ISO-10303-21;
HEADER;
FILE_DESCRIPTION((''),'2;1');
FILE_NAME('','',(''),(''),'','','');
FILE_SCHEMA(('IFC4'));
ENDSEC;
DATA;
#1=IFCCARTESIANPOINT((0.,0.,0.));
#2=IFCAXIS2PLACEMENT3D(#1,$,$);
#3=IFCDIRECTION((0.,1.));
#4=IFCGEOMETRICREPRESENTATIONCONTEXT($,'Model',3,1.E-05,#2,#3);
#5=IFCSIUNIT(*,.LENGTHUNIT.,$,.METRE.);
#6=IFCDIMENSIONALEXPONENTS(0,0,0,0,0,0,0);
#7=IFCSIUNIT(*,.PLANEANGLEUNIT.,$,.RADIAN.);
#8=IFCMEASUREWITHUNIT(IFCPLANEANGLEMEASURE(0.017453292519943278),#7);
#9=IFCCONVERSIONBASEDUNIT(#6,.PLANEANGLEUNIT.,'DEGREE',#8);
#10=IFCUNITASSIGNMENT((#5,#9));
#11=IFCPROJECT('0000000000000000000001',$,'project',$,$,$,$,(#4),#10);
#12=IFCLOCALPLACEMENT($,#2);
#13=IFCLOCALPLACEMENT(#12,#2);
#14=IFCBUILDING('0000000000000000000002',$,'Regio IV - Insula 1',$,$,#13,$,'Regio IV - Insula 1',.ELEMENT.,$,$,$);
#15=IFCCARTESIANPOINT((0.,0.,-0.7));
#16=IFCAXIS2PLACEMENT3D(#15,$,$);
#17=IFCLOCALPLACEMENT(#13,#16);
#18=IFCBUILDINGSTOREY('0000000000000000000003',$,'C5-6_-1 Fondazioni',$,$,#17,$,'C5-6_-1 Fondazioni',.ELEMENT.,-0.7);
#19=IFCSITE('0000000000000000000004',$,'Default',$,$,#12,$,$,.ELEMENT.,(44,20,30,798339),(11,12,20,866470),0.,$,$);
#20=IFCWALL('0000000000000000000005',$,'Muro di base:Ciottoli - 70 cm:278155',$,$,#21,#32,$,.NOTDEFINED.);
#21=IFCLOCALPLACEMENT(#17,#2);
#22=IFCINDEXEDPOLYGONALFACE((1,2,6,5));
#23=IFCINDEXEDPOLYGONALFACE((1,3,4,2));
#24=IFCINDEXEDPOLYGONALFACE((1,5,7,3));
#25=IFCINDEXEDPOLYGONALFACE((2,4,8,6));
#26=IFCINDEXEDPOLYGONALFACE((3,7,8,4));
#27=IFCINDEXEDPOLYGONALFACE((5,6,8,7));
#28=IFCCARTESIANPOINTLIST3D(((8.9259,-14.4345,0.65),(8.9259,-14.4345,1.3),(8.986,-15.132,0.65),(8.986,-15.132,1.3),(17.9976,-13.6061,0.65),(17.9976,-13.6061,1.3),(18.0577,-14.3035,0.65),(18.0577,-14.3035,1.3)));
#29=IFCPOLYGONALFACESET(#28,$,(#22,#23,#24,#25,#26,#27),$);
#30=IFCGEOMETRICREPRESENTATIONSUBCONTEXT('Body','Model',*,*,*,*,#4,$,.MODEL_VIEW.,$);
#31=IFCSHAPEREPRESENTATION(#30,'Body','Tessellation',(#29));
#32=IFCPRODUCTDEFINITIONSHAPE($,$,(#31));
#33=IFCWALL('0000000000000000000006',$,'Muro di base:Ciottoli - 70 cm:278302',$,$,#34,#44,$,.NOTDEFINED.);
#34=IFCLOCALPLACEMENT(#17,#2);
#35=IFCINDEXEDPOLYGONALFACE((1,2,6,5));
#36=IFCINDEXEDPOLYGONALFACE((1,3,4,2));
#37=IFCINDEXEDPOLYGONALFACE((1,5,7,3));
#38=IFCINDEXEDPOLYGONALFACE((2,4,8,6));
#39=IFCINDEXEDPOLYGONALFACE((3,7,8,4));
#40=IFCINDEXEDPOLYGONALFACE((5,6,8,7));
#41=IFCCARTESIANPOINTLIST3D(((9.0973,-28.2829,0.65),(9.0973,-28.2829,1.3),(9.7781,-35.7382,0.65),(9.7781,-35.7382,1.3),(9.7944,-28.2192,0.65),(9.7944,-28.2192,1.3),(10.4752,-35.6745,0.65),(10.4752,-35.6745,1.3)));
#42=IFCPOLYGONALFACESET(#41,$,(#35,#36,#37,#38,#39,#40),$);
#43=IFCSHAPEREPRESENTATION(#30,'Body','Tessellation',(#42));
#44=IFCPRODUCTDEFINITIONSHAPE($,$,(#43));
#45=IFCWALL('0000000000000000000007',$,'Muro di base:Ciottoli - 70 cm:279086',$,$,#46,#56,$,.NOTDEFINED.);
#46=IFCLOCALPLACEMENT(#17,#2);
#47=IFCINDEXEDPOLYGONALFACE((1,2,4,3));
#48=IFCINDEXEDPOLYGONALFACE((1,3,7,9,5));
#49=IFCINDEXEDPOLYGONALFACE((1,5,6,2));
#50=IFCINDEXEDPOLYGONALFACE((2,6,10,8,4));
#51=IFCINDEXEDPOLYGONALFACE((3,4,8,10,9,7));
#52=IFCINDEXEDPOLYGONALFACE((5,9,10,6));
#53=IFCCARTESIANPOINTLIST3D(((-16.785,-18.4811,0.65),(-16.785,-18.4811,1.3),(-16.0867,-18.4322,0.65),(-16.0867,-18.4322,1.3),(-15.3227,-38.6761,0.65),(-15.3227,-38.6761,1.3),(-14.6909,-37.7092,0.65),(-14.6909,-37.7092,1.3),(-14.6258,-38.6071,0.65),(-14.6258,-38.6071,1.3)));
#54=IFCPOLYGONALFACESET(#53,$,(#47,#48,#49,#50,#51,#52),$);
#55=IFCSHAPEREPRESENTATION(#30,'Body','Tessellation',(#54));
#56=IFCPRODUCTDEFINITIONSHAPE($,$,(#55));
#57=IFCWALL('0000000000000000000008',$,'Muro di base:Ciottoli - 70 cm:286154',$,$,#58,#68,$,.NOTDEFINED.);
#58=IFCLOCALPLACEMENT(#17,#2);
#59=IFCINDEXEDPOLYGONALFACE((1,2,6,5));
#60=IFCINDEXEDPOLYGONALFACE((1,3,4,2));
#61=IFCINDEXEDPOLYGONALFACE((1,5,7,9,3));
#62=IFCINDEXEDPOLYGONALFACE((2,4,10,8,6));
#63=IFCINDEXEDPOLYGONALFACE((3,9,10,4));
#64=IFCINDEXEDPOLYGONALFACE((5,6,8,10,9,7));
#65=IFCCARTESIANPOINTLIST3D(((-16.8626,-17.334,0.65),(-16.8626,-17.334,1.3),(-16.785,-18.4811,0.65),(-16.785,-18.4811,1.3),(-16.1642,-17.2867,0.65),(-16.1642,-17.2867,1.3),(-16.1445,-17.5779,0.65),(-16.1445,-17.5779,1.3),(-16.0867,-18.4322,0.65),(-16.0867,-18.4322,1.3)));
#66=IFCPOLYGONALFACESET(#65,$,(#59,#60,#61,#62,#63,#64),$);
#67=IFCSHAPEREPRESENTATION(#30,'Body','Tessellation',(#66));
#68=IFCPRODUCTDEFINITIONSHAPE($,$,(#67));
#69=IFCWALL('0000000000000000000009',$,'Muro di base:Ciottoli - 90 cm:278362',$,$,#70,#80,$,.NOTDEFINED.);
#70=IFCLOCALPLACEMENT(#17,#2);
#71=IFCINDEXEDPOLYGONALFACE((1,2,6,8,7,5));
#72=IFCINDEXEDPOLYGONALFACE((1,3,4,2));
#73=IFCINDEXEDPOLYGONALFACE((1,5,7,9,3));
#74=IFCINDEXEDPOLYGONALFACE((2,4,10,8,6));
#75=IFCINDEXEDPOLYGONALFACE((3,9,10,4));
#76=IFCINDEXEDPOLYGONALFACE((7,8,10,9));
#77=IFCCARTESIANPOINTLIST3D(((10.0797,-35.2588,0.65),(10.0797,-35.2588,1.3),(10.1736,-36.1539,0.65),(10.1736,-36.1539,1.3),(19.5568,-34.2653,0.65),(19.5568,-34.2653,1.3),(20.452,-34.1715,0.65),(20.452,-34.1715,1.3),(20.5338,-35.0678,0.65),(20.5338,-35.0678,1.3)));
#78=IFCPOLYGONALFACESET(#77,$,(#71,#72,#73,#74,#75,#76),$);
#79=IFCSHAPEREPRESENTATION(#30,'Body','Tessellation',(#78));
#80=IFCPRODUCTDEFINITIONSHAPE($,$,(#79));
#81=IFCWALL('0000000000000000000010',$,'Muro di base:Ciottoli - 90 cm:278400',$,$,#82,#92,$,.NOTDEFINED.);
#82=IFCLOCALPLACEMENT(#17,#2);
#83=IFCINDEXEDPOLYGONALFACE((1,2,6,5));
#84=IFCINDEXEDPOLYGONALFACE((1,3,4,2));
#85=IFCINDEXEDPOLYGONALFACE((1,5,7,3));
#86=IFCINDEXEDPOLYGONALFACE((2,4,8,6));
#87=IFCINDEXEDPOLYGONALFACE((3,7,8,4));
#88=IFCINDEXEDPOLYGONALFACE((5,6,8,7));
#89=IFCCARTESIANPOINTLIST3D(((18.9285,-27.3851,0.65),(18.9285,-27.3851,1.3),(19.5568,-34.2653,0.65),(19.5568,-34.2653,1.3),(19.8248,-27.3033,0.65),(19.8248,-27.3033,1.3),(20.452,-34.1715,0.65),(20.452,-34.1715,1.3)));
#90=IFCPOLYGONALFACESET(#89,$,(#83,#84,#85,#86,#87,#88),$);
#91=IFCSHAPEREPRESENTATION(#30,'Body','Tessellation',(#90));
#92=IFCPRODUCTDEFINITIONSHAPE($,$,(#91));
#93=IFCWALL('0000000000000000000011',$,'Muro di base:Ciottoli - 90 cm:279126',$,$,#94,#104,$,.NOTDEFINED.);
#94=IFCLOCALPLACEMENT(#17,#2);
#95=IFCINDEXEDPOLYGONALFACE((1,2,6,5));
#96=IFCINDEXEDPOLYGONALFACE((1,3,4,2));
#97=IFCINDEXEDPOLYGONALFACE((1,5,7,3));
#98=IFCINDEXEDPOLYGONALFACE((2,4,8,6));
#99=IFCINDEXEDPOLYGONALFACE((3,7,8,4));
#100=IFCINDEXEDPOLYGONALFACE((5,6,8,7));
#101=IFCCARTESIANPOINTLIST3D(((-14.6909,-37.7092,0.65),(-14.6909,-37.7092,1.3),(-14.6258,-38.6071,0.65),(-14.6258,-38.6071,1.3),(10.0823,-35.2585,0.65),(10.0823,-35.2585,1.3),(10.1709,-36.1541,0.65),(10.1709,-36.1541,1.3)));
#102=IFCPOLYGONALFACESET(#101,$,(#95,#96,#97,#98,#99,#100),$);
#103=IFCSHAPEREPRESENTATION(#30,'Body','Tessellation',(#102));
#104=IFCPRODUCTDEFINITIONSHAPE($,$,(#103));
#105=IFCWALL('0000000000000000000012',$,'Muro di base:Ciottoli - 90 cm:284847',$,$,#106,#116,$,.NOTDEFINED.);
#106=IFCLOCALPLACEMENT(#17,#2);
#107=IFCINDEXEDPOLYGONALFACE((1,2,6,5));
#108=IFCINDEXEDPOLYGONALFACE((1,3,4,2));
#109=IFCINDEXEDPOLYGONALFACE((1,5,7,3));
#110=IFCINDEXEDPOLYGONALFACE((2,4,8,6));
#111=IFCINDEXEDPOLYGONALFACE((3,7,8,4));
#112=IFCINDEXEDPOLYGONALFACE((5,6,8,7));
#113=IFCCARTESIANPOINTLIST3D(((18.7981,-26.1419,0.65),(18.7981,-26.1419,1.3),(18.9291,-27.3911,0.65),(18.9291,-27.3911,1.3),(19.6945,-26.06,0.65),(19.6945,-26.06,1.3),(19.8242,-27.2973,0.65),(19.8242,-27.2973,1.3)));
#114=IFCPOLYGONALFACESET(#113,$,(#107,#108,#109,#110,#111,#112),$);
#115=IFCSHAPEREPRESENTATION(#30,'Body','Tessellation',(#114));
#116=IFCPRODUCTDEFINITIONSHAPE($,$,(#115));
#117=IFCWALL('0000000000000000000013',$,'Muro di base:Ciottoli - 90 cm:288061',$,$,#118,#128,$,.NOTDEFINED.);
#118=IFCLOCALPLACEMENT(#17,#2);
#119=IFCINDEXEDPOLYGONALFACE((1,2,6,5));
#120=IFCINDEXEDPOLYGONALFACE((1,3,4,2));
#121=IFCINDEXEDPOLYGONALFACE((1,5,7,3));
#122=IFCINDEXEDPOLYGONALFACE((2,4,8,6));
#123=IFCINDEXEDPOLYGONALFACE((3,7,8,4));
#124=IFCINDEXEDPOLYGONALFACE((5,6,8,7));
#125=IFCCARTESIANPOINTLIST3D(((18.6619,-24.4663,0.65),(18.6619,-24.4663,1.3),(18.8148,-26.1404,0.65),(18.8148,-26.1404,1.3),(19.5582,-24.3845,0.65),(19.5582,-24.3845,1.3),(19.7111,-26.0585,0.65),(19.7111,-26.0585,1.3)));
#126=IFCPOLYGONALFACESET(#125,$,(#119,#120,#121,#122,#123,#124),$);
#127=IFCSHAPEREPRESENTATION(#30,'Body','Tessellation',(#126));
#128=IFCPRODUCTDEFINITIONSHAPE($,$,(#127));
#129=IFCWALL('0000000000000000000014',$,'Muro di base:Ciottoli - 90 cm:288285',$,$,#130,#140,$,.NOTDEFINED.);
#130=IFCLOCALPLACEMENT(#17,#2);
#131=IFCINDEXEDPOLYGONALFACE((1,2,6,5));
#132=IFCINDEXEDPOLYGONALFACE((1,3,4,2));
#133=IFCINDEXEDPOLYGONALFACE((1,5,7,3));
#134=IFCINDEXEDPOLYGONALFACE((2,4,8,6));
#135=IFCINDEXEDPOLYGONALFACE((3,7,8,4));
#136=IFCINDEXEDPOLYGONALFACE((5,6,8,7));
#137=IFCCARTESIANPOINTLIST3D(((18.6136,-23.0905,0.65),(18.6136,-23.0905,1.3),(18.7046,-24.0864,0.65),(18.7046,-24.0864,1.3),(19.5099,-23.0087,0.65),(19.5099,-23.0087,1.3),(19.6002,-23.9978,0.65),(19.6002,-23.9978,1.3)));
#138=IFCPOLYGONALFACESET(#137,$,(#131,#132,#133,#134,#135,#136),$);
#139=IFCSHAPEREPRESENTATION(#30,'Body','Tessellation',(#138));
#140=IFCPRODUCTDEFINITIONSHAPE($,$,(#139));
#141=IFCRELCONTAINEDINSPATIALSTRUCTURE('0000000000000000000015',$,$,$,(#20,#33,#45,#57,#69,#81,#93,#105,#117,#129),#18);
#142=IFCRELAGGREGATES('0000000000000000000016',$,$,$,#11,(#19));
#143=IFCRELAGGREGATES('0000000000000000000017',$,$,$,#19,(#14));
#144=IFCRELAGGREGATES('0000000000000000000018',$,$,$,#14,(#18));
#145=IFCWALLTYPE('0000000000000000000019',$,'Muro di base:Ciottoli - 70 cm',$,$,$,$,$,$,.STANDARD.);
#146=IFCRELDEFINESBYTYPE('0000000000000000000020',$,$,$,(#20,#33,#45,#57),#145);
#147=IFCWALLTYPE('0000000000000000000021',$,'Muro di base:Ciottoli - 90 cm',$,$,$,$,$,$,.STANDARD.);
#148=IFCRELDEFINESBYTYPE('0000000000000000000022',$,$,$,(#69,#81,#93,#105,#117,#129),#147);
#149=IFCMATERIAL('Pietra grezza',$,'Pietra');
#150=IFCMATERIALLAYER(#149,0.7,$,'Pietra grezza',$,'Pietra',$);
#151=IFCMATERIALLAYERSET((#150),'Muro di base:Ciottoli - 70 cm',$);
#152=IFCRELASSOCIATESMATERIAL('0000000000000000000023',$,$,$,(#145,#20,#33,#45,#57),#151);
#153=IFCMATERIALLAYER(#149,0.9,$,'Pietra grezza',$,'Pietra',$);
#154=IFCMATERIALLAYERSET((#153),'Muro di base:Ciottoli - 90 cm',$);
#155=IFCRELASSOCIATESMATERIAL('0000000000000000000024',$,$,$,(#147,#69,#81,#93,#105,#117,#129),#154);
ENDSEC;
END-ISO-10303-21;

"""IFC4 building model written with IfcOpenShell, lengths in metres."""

from ifc_helpers import new_model, entity, si_unit, converted_unit, direction, frame, frame_2d, origin, place, context, subcontext, project, spatial, polyline, rectangle, outline, extrude, material, layer, layer_set, layer_usage, type_object, element, save


model = new_model("IFC4")

# Units and contexts
model_context = context("Model", 3, precision=1e-05, world=origin(), true_north=direction((0.0, 1.0)))
body_context = subcontext(model_context, "Body", "Model", "MODEL_VIEW")
ifc_project = project(units=[si_unit("LENGTHUNIT", "METRE"), converted_unit("PLANEANGLEUNIT", "DEGREE", entity("IfcPlaneAngleMeasure", 0.017453292519943278), si_unit("PLANEANGLEUNIT", "RADIAN"), dimensions=[0, 0, 0, 0, 0, 0, 0])], contexts=[model_context])

# Site, building, storey
site_placement = place(None, origin())
site = spatial("IfcSite", under=ifc_project, at=site_placement, Name="Default", CompositionType="ELEMENT", RefLatitude=(44, 20, 30, 798339), RefLongitude=(11, 12, 20, 866470), RefElevation=0.0)
building_placement = place(site_placement, origin())
building = spatial("IfcBuilding", under=site, at=building_placement, Name="Regio IV - Insula 1", LongName="Regio IV - Insula 1", CompositionType="ELEMENT")
storey_placement = place(building_placement, frame((0.0, 0.0, -0.7)))
storey = spatial("IfcBuildingStorey", under=building, at=storey_placement, Name="C5-6_-1 Fondazioni", LongName="C5-6_-1 Fondazioni", CompositionType="ELEMENT", Elevation=-0.7)

# Walls
ifc_material = material(Name="Pietra grezza", Category="Pietra")
ifc_layer_1 = layer(ifc_material, 0.7, Name="Pietra grezza", Category="Pietra")
ifc_layer_set_1 = layer_set([ifc_layer_1], Name="Muro di base:Ciottoli - 70 cm")
wall_type_1 = type_object("IfcWallType", Name="Muro di base:Ciottoli - 70 cm", PredefinedType="STANDARD", material=ifc_layer_set_1)
ifc_layer_usage_1 = layer_usage(ifc_layer_set_1, "AXIS2", "NEGATIVE", 0.35)
wall_1_placement = place(storey_placement, frame((18.0294, -13.9547, 0.65), z_axis=(0.0, 0.0, 1.0), x_axis=(-0.995856, -0.090941, 0.0)))
element("IfcWall", 1, at=wall_1_placement, inside=storey, type_object=wall_type_1, material=ifc_layer_usage_1, Name="Muro di base:Ciottoli - 70 cm:278155", PredefinedType="NOTDEFINED", context=body_context, shape_type="SweptSolid", body=[
    extrude(outline(polyline([(9.1094, -0.35), (9.1131, 0.35), (0.0036, 0.35), (0.0, -0.35), (9.1094, -0.35)])), origin(), (0.0, 0.0, 1.0), 0.65),
])
ifc_layer_usage_2 = layer_usage(ifc_layer_set_1, "AXIS2", "NEGATIVE", 0.35)
wall_2_placement = place(storey_placement, frame((9.4458, -28.251, 0.65), z_axis=(0.0, 0.0, 1.0), x_axis=(0.09094, -0.995856, 0.0)))
element("IfcWall", 2, at=wall_2_placement, inside=storey, type_object=wall_type_1, material=ifc_layer_usage_2, Name="Muro di base:Ciottoli - 70 cm:278302", PredefinedType="NOTDEFINED", context=body_context, shape_type="SweptSolid", body=[
    extrude(rectangle(XDim=7.4863, YDim=0.7, at=frame_2d((3.7432, 0.0), x_axis=(-1.0, 0.0))), origin(), (0.0, 0.0, 1.0), 0.65),
])

# Walls
ifc_layer_usage_3 = layer_usage(ifc_layer_set_1, "AXIS2", "NEGATIVE", 0.35)
wall_3_placement = place(storey_placement, frame((-16.4359, -18.4558, 0.65), z_axis=(0.0, 0.0, 1.0), x_axis=(0.07222, -0.997389, 0.0)))
element("IfcWall", 3, at=wall_3_placement, inside=storey, type_object=wall_type_1, material=ifc_layer_usage_3, Name="Muro di base:Ciottoli - 70 cm:279086", PredefinedType="NOTDEFINED", context=body_context, shape_type="SweptSolid", body=[
    extrude(outline(polyline([(20.2478, -0.35), (20.2294, 0.35), (19.3291, 0.35), (0.0016, 0.35), (0.0, -0.35), (20.2478, -0.35)])), origin(), (0.0, 0.0, 1.0), 0.65),
])
ifc_layer_usage_4 = layer_usage(ifc_layer_set_1, "AXIS2", "NEGATIVE", 0.35)
wall_4_placement = place(storey_placement, frame((-16.4358, -18.4575, 0.65), z_axis=(0.0, 0.0, 1.0), x_axis=(-0.067526, 0.997718, 0.0)))
element("IfcWall", 4, at=wall_4_placement, inside=storey, type_object=wall_type_1, material=ifc_layer_usage_4, Name="Muro di base:Ciottoli - 70 cm:286154", PredefinedType="NOTDEFINED", context=body_context, shape_type="SweptSolid", body=[
    extrude(outline(polyline([(1.1498, -0.35), (1.1498, 0.35), (0.0, 0.35), (0.0016, -0.35), (0.8579, -0.35), (1.1498, -0.35)])), origin(), (0.0, 0.0, 1.0), 0.65),
])
ifc_layer_2 = layer(ifc_material, 0.9, Name="Pietra grezza", Category="Pietra")
ifc_layer_set_2 = layer_set([ifc_layer_2], Name="Muro di base:Ciottoli - 90 cm")
ifc_layer_usage_5 = layer_usage(ifc_layer_set_2, "AXIS2", "NEGATIVE", 0.45)
wall_type_2 = type_object("IfcWallType", Name="Muro di base:Ciottoli - 90 cm", PredefinedType="STANDARD", material=ifc_layer_set_2)
wall_5_placement = place(storey_placement, frame((10.1266, -35.7063, 0.65), z_axis=(0.0, 0.0, 1.0), x_axis=(0.99455, 0.104256, 0.0)))
element("IfcWall", 5, at=wall_5_placement, inside=storey, type_object=wall_type_2, material=ifc_layer_usage_5, Name="Muro di base:Ciottoli - 90 cm:278362", PredefinedType="NOTDEFINED", context=body_context, shape_type="SweptSolid", body=[
    extrude(outline(polyline([(10.417, -0.45), (10.4291, 0.45), (9.529, 0.45), (0.0, 0.45), (0.0, -0.45), (10.417, -0.45)])), origin(), (0.0, 0.0, 1.0), 0.65),
])
ifc_layer_usage_6 = layer_usage(ifc_layer_set_2, "AXIS2", "NEGATIVE", 0.45)
wall_6_placement = place(storey_placement, frame((20.0049, -34.2244, 0.65), z_axis=(0.0, 0.0, 1.0), x_axis=(-0.090941, 0.995856, 0.0)))
element("IfcWall", 6, at=wall_6_placement, inside=storey, type_object=wall_type_2, material=ifc_layer_usage_6, Name="Muro di base:Ciottoli - 90 cm:278400", PredefinedType="NOTDEFINED", context=body_context, shape_type="SweptSolid", body=[
    extrude(outline(polyline([(6.9089, -0.45), (6.9089, 0.45), (0.0, 0.45), (0.012, -0.45), (6.9089, -0.45)])), origin(), (0.0, 0.0, 1.0), 0.65),
])
ifc_layer_usage_7 = layer_usage(ifc_layer_set_2, "AXIS2", "NEGATIVE", 0.45)
wall_7_placement = place(storey_placement, frame((-14.6701, -38.1593, 0.65), z_axis=(0.0, 0.0, 1.0), x_axis=(0.995143, 0.098443, 0.0)))
element("IfcWall", 7, at=wall_7_placement, inside=storey, type_object=wall_type_2, material=ifc_layer_usage_7, Name="Muro di base:Ciottoli - 90 cm:279126", PredefinedType="NOTDEFINED", context=body_context, shape_type="SweptSolid", body=[
    extrude(outline(polyline([(24.9178, -0.45), (24.9178, 0.45), (0.0237, 0.45), (0.0, -0.45), (24.9178, -0.45)])), origin(), (0.0, 0.0, 1.0), 0.65),
])
ifc_layer_usage_8 = layer_usage(ifc_layer_set_2, "AXIS2", "NEGATIVE", 0.45)
wall_8_placement = place(storey_placement, frame((19.3766, -27.3442, 0.65), z_axis=(0.0, 0.0, 1.0), x_axis=(-0.104256, 0.99455, 0.0)))
element("IfcWall", 8, at=wall_8_placement, inside=storey, type_object=wall_type_2, material=ifc_layer_usage_8, Name="Muro di base:Ciottoli - 90 cm:284847", PredefinedType="NOTDEFINED", context=body_context, shape_type="SweptSolid", body=[
    extrude(outline(polyline([(1.244, -0.45), (1.2561, 0.45), (0.0, 0.45), (0.0, -0.45), (1.244, -0.45)])), origin(), (0.0, 0.0, 1.0), 0.65),
])
ifc_layer_usage_9 = layer_usage(ifc_layer_set_2, "AXIS2", "NEGATIVE", 0.45)
wall_9_placement = place(storey_placement, frame((19.2629, -26.0994, 0.65), z_axis=(0.0, 0.0, 1.0), x_axis=(-0.090941, 0.995856, 0.0)))
element("IfcWall", 9, at=wall_9_placement, inside=storey, type_object=wall_type_2, material=ifc_layer_usage_9, Name="Muro di base:Ciottoli - 90 cm:288061", PredefinedType="NOTDEFINED", context=body_context, shape_type="SweptSolid", body=[
    extrude(rectangle(XDim=1.681, YDim=0.9, at=frame_2d((0.8405, 0.0), x_axis=(-1.0, 0.0))), origin(), (0.0, 0.0, 1.0), 0.65),
])
ifc_layer_usage_10 = layer_usage(ifc_layer_set_2, "AXIS2", "NEGATIVE", 0.45)
wall_10_placement = place(storey_placement, frame((19.0618, -23.0496, 0.65), z_axis=(0.0, 0.0, 1.0), x_axis=(0.09094, -0.995856, 0.0)))
element("IfcWall", 10, at=wall_10_placement, inside=storey, type_object=wall_type_2, material=ifc_layer_usage_10, Name="Muro di base:Ciottoli - 90 cm:288285", PredefinedType="NOTDEFINED", context=body_context, shape_type="SweptSolid", body=[
    extrude(outline(polyline([(1.0, -0.45), (0.9932, 0.45), (0.0, 0.45), (0.0, -0.45), (1.0, -0.45)])), origin(), (0.0, 0.0, 1.0), 0.65),
])

save(model, "model.ifc")
